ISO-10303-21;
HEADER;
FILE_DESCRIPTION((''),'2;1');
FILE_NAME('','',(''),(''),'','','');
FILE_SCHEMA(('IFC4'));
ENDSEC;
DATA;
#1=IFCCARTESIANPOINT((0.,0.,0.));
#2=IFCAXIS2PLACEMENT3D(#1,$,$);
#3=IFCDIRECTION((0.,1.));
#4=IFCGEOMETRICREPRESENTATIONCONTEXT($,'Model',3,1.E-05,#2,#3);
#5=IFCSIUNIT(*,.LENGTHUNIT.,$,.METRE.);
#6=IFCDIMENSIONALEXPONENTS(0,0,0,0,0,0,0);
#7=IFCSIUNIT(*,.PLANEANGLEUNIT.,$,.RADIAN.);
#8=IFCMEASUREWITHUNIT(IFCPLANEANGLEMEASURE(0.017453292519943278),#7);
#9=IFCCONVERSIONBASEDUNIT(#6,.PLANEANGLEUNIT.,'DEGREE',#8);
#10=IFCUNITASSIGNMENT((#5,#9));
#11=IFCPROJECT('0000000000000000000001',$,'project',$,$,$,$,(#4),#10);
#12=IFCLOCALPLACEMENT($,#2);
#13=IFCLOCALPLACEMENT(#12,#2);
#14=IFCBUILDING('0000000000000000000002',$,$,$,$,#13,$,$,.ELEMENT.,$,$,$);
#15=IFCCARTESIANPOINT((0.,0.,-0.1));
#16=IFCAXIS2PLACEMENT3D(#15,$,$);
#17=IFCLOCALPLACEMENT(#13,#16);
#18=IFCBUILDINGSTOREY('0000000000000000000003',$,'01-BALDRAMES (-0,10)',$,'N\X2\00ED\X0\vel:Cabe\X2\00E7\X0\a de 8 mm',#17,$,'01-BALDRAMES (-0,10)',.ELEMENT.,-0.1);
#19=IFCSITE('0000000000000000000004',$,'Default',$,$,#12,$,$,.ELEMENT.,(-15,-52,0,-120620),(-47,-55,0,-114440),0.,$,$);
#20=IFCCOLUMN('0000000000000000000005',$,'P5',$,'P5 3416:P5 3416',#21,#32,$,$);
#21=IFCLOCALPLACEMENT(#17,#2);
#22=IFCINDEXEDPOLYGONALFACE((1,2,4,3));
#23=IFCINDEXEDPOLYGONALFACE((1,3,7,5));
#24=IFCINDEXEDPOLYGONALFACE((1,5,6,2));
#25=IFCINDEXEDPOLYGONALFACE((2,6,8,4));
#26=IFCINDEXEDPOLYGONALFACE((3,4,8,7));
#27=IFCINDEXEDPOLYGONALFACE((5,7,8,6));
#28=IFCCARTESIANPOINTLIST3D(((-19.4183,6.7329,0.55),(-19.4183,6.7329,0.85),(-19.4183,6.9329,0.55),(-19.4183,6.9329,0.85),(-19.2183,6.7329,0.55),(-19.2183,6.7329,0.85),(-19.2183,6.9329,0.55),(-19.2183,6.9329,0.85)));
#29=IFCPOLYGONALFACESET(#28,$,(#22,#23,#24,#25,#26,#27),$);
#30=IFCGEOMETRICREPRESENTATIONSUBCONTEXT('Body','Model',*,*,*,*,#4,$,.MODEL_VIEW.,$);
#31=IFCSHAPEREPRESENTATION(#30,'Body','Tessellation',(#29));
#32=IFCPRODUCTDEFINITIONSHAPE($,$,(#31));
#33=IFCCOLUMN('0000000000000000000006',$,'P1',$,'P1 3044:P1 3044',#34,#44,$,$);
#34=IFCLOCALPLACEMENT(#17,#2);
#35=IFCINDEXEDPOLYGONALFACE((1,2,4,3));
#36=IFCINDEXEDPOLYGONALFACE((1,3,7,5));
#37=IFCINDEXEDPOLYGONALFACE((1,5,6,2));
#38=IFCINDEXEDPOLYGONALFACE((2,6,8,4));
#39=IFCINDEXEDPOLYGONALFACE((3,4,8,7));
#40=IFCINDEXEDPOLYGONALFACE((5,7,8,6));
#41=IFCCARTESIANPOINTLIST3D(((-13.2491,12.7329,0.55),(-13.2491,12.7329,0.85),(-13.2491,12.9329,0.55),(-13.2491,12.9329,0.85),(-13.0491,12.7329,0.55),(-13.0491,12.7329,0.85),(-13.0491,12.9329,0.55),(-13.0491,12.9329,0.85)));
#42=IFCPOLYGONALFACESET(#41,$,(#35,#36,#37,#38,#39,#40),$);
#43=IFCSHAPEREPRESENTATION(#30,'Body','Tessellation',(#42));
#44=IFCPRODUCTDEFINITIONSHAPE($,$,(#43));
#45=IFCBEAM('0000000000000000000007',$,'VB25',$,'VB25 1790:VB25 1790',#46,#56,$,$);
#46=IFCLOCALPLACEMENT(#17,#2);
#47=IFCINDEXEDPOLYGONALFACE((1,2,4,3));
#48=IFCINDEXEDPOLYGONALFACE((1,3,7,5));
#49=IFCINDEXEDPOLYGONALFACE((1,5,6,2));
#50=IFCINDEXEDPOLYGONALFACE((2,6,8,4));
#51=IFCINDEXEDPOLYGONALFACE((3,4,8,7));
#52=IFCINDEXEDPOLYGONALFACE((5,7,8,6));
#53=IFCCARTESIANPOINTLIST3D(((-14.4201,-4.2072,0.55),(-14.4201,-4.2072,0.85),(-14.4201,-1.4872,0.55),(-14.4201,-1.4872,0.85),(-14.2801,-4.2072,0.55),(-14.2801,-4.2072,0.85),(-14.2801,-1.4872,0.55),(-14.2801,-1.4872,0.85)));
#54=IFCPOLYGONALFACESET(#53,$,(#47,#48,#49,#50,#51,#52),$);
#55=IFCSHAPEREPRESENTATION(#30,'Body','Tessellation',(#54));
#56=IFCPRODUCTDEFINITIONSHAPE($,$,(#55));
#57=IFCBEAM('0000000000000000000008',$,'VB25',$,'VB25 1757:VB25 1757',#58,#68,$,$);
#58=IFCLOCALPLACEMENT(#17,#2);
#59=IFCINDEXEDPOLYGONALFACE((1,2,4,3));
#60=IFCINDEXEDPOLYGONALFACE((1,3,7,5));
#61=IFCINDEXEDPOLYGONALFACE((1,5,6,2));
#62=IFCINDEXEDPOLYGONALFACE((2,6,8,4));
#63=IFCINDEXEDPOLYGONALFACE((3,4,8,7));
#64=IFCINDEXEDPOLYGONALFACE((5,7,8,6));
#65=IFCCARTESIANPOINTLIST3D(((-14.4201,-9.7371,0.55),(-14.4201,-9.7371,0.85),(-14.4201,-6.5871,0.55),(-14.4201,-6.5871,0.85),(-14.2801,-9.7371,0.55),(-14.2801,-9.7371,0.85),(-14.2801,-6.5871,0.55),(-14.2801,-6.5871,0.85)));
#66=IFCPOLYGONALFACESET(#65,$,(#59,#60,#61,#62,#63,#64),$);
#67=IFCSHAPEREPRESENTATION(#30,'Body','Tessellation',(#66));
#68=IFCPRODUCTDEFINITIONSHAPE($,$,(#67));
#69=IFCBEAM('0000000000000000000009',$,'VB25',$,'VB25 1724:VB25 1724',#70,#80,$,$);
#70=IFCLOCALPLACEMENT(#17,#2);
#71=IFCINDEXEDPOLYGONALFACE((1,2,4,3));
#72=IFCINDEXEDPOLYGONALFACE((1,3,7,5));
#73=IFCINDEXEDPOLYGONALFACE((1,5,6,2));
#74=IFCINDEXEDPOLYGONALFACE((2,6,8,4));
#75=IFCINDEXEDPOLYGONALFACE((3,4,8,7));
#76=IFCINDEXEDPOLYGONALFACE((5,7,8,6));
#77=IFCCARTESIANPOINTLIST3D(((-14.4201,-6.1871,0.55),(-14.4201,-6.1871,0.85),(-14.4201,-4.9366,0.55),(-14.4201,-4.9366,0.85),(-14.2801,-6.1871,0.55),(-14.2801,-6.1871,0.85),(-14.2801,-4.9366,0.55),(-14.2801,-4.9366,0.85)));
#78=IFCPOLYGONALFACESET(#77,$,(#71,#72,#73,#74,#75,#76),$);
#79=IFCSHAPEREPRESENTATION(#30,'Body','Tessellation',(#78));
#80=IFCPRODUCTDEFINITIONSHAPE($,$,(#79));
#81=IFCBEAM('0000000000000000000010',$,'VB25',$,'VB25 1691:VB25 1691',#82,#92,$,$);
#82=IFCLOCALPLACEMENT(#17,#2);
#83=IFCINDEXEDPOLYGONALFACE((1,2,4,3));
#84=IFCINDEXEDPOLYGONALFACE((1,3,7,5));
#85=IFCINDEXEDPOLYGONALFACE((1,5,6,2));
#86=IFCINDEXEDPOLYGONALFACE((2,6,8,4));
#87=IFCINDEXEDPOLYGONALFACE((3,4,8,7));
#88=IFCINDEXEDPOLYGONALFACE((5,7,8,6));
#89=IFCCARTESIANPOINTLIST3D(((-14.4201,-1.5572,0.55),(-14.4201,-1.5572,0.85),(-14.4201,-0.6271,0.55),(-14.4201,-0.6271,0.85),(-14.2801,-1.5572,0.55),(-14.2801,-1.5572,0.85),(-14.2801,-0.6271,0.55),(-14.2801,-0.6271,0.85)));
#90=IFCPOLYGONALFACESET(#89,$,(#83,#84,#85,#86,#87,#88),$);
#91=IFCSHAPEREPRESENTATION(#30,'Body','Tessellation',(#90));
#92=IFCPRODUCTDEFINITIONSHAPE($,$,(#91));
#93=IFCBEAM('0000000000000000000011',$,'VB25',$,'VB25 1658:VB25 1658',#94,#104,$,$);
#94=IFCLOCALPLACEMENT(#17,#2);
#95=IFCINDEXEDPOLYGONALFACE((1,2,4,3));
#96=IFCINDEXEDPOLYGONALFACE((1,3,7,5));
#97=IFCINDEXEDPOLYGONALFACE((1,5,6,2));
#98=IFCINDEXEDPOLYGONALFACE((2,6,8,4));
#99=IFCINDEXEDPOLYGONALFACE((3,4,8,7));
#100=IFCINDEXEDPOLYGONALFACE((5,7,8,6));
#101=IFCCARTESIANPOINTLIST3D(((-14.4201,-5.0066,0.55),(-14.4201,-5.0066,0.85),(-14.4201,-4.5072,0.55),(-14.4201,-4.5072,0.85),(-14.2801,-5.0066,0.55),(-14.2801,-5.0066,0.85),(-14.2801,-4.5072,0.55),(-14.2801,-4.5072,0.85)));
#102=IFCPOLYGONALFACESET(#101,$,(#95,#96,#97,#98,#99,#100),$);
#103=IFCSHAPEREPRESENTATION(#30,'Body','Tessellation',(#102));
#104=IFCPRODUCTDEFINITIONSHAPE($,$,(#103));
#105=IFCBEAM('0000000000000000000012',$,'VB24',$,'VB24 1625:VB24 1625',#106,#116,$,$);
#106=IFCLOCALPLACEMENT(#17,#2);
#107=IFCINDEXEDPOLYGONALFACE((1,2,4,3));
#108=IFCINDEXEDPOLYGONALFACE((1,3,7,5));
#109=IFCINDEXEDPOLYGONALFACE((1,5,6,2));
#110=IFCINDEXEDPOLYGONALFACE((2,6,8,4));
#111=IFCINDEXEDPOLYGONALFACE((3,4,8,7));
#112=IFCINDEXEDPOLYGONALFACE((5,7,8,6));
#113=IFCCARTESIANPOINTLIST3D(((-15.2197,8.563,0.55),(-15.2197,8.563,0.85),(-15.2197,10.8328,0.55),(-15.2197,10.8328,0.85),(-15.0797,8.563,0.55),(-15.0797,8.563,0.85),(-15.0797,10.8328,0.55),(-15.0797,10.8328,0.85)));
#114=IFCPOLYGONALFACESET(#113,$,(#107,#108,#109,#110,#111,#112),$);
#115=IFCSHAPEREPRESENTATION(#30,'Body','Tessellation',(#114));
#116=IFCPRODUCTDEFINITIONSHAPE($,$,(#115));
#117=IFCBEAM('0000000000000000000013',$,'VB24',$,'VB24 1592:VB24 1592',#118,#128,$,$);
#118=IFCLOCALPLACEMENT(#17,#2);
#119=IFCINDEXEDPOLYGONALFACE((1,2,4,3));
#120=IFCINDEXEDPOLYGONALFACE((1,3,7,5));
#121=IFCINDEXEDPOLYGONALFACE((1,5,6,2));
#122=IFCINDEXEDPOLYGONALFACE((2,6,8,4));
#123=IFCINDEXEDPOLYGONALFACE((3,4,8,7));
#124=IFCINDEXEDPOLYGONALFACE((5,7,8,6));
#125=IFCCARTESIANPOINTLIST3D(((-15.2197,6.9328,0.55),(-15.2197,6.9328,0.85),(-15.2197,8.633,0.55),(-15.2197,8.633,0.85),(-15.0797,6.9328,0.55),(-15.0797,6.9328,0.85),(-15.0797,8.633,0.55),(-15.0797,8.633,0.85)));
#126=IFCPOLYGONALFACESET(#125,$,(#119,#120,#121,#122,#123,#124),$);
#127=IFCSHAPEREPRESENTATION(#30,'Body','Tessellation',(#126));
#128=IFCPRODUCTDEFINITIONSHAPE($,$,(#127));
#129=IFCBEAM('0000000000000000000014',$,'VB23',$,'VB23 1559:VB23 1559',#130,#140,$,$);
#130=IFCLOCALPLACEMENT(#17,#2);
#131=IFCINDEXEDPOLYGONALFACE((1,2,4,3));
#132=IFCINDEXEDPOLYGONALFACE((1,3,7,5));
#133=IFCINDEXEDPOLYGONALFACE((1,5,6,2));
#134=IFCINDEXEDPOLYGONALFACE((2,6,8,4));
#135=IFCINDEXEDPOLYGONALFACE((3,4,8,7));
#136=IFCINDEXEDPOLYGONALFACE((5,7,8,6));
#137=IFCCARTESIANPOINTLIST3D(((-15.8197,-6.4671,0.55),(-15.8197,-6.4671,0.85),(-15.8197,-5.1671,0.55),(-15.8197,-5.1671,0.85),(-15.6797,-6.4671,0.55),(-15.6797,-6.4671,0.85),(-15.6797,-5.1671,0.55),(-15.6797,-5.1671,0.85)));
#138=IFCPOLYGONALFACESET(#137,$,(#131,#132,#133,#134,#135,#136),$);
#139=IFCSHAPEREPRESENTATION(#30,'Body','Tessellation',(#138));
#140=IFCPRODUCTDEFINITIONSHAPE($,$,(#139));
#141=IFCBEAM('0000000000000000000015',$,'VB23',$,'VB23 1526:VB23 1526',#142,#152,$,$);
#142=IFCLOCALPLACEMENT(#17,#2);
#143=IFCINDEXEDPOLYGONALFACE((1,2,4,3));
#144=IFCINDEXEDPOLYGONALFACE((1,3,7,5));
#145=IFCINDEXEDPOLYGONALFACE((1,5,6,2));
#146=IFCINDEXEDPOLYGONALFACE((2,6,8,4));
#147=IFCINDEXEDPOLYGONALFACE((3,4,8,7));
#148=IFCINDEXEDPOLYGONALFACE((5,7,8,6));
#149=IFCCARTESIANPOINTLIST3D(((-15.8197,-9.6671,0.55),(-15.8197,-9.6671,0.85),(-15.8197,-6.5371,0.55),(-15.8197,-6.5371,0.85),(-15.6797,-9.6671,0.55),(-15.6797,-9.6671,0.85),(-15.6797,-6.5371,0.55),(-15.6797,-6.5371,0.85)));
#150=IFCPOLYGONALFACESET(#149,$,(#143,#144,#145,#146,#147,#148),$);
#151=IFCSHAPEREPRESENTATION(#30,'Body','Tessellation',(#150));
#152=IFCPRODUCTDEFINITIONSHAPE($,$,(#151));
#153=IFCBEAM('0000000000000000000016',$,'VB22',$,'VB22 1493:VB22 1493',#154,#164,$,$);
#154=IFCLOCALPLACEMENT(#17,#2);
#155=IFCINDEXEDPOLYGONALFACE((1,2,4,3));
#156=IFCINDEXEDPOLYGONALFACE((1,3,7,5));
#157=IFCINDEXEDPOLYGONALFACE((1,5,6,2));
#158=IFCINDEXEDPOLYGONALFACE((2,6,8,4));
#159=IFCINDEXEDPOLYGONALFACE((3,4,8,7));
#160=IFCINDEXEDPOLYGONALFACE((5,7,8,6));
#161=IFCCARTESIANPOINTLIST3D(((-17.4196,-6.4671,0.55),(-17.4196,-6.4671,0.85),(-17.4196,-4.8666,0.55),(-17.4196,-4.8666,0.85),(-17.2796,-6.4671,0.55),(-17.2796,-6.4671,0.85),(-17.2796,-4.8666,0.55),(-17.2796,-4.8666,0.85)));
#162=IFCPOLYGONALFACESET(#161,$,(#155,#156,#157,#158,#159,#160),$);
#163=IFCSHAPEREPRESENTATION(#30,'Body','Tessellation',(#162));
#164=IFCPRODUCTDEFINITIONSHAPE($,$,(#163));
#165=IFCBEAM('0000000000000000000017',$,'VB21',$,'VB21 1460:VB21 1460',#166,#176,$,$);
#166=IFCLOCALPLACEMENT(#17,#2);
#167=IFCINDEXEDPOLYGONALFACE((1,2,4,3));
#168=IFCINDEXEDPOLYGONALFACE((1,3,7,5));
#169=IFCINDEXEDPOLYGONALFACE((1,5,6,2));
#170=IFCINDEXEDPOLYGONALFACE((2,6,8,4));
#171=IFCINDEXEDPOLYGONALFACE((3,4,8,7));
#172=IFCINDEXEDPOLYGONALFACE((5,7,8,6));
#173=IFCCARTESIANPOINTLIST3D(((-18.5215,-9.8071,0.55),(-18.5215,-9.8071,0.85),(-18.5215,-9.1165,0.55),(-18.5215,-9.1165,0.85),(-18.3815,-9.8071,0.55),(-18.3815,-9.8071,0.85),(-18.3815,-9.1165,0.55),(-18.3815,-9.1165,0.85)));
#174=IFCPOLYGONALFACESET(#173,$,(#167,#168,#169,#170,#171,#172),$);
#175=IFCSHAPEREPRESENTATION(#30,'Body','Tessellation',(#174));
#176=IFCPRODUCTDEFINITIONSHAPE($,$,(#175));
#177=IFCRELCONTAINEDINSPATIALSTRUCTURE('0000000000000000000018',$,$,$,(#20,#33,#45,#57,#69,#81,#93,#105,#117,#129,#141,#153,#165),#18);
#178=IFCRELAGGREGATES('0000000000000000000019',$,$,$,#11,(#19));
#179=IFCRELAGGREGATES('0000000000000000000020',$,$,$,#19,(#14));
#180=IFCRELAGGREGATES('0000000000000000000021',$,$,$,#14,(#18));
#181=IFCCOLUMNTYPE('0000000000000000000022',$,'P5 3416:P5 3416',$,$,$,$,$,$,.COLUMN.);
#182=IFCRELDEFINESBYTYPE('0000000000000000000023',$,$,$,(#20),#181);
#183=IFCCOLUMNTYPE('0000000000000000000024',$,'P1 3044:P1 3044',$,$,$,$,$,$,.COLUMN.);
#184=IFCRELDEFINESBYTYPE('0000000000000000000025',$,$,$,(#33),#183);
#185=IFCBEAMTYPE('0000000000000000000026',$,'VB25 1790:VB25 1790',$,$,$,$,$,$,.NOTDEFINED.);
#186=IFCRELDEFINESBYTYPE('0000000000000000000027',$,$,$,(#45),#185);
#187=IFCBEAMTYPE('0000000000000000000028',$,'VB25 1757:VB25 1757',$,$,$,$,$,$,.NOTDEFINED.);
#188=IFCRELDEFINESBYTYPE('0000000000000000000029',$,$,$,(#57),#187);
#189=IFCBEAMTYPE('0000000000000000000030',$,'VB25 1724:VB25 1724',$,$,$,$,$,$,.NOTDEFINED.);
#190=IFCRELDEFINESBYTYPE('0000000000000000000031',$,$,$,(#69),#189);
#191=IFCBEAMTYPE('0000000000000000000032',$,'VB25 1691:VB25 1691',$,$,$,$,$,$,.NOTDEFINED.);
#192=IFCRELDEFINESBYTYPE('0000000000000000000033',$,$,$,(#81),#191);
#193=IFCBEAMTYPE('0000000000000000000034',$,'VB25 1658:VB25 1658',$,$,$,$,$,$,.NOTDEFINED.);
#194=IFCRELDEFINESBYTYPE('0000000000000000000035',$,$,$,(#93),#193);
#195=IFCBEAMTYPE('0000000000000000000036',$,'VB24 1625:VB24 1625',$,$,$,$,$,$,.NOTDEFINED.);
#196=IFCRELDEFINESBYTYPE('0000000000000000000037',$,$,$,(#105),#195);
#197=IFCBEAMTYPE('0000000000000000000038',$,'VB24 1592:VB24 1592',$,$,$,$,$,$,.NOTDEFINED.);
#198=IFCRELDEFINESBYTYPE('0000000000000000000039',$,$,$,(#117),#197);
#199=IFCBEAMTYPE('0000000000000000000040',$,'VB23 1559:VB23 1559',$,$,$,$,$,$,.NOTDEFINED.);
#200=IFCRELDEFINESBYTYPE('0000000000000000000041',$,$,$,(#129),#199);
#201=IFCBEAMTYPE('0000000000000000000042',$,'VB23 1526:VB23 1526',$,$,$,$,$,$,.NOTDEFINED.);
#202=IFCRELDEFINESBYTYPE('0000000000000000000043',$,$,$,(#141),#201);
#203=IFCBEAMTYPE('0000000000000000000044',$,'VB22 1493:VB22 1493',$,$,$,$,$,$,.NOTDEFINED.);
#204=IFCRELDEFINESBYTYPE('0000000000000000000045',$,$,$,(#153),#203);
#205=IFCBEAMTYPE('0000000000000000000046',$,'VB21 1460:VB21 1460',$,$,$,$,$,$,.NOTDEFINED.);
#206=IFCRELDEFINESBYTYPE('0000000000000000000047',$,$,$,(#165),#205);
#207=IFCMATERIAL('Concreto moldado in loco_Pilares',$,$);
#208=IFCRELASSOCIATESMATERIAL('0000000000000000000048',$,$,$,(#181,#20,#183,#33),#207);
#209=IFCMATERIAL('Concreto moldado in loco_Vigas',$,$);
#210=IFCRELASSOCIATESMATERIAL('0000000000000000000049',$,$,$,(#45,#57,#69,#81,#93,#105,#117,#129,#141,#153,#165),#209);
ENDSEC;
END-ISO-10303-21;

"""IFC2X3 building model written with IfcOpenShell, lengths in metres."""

from ifc_helpers import new_model, entity, si_unit, converted_unit, direction, frame, frame_2d, origin, origin_2d_with_axis, place, context, subcontext, project, spatial, rectangle, extrude, source, transform, mapped, material, type_object, type_shapes, element, save


model = new_model("IFC2X3")

# Units and contexts
model_context = context("Model", 3, precision=1e-05, world=origin(), true_north=direction((0.0, 1.0)))
body_context = subcontext(model_context, "Body", "Model", "MODEL_VIEW")
ifc_project = project(units=[si_unit("LENGTHUNIT", "METRE"), converted_unit("PLANEANGLEUNIT", "DEGREE", entity("IfcPlaneAngleMeasure", 0.017453292519943278), si_unit("PLANEANGLEUNIT", "RADIAN"), dimensions=[0, 0, 0, 0, 0, 0, 0])], contexts=[model_context])

# Site, building, storey
site_placement = place(None, origin())
site = spatial("IfcSite", under=ifc_project, at=site_placement, Name="Default", CompositionType="ELEMENT", RefLatitude=(-15, -52, 0, -120620), RefLongitude=(-47, -55, 0, -114440), RefElevation=0.0)
building_placement = place(site_placement, origin())
building = spatial("IfcBuilding", under=site, at=building_placement, CompositionType="ELEMENT")
storey_placement = place(building_placement, frame((0.0, 0.0, -0.1)))
storey = spatial("IfcBuildingStorey", under=building, at=storey_placement, Name="01-BALDRAMES (-0,10)", ObjectType="Nível:Cabeça de 8 mm", LongName="01-BALDRAMES (-0,10)", CompositionType="ELEMENT", Elevation=-0.1)

# Columns
ifc_material_1 = material(Name="Concreto moldado in loco_Pilares")
column_type_1 = type_object("IfcColumnType", Name="P5 3416:P5 3416", PredefinedType="COLUMN", material=ifc_material_1)
shared_shape_1 = source(origin(), body_context, "Body", "SweptSolid", [
    extrude(rectangle(XDim=0.2, YDim=0.2, at=origin_2d_with_axis()), frame((0.0, 0.0, 0.45), z_axis=(0.0, 0.0, 1.0), x_axis=(0.0, -1.0, 0.0)), (0.0, 0.0, 1.0), 0.3),
])
type_shapes(column_type_1, [shared_shape_1])
column_1_placement = place(storey_placement, frame((-19.3183, 6.8329, 0.1)))
element("IfcColumn", 1, at=column_1_placement, inside=storey, type_object=column_type_1, material=ifc_material_1, Name="P5", ObjectType="P5 3416:P5 3416", context=body_context, shape_type="MappedRepresentation", body=[
    mapped(shared_shape_1, transform((0.0, 0.0, 0.0), scale=1.0)),
])
column_type_2 = type_object("IfcColumnType", Name="P1 3044:P1 3044", PredefinedType="COLUMN", material=ifc_material_1)
shared_shape_2 = source(origin(), body_context, "Body", "SweptSolid", [
    extrude(rectangle(XDim=0.2, YDim=0.2, at=origin_2d_with_axis()), frame((0.0, 0.0, 0.45), z_axis=(0.0, 0.0, 1.0), x_axis=(0.0, 1.0, 0.0)), (0.0, 0.0, 1.0), 0.3),
])
type_shapes(column_type_2, [shared_shape_2])
column_2_placement = place(storey_placement, frame((-13.1491, 12.8329, 0.1)))
element("IfcColumn", 2, at=column_2_placement, inside=storey, type_object=column_type_2, material=ifc_material_1, Name="P1", ObjectType="P1 3044:P1 3044", context=body_context, shape_type="MappedRepresentation", body=[
    mapped(shared_shape_2, transform((0.0, 0.0, 0.0), scale=1.0)),
])

# Beams
ifc_material_2 = material(Name="Concreto moldado in loco_Vigas")
beam_type_1 = type_object("IfcBeamType", Name="VB25 1790:VB25 1790", PredefinedType="NOTDEFINED")
beam_1_placement = place(storey_placement, origin())
element("IfcBeam", 3, at=beam_1_placement, inside=storey, type_object=beam_type_1, material=ifc_material_2, Name="VB25", ObjectType="VB25 1790:VB25 1790", context=body_context, shape_type="SweptSolid", body=[
    extrude(rectangle(XDim=0.3, YDim=2.72, at=frame_2d((0.0, 0.0), x_axis=(0.0, 1.0))), frame((-14.4201, -2.8472, 0.7), z_axis=(1.0, 0.0, 0.0), x_axis=(0.0, -1.0, 0.0)), (0.0, 0.0, 1.0), 0.14),
])
beam_type_2 = type_object("IfcBeamType", Name="VB25 1757:VB25 1757", PredefinedType="NOTDEFINED")
beam_2_placement = place(storey_placement, origin())
element("IfcBeam", 4, at=beam_2_placement, inside=storey, type_object=beam_type_2, material=ifc_material_2, Name="VB25", ObjectType="VB25 1757:VB25 1757", context=body_context, shape_type="SweptSolid", body=[
    extrude(rectangle(XDim=0.3, YDim=3.15, at=frame_2d((0.0, 0.0), x_axis=(0.0, 1.0))), frame((-14.4201, -8.1621, 0.7), z_axis=(1.0, 0.0, 0.0), x_axis=(0.0, -1.0, 0.0)), (0.0, 0.0, 1.0), 0.14),
])
beam_type_3 = type_object("IfcBeamType", Name="VB25 1724:VB25 1724", PredefinedType="NOTDEFINED")
beam_3_placement = place(storey_placement, origin())
element("IfcBeam", 5, at=beam_3_placement, inside=storey, type_object=beam_type_3, material=ifc_material_2, Name="VB25", ObjectType="VB25 1724:VB25 1724", context=body_context, shape_type="SweptSolid", body=[
    extrude(rectangle(XDim=0.3, YDim=1.2505, at=frame_2d((0.0, 0.0), x_axis=(0.0, 1.0))), frame((-14.4201, -5.5618, 0.7), z_axis=(1.0, 0.0, 0.0), x_axis=(0.0, -1.0, 0.0)), (0.0, 0.0, 1.0), 0.14),
])
beam_type_4 = type_object("IfcBeamType", Name="VB25 1691:VB25 1691", PredefinedType="NOTDEFINED")
beam_4_placement = place(storey_placement, origin())
element("IfcBeam", 6, at=beam_4_placement, inside=storey, type_object=beam_type_4, material=ifc_material_2, Name="VB25", ObjectType="VB25 1691:VB25 1691", context=body_context, shape_type="SweptSolid", body=[
    extrude(rectangle(XDim=0.3, YDim=0.9301, at=frame_2d((0.0, 0.0), x_axis=(0.0, 1.0))), frame((-14.4201, -1.0921, 0.7), z_axis=(1.0, 0.0, 0.0), x_axis=(0.0, -1.0, 0.0)), (0.0, 0.0, 1.0), 0.14),
])
beam_type_5 = type_object("IfcBeamType", Name="VB25 1658:VB25 1658", PredefinedType="NOTDEFINED")
beam_5_placement = place(storey_placement, origin())
element("IfcBeam", 7, at=beam_5_placement, inside=storey, type_object=beam_type_5, material=ifc_material_2, Name="VB25", ObjectType="VB25 1658:VB25 1658", context=body_context, shape_type="SweptSolid", body=[
    extrude(rectangle(XDim=0.3, YDim=0.4994, at=frame_2d((0.0, 0.0), x_axis=(0.0, 1.0))), frame((-14.4201, -4.7569, 0.7), z_axis=(1.0, 0.0, 0.0), x_axis=(0.0, -1.0, 0.0)), (0.0, 0.0, 1.0), 0.14),
])
beam_type_6 = type_object("IfcBeamType", Name="VB24 1625:VB24 1625", PredefinedType="NOTDEFINED")
beam_6_placement = place(storey_placement, origin())
element("IfcBeam", 8, at=beam_6_placement, inside=storey, type_object=beam_type_6, material=ifc_material_2, Name="VB24", ObjectType="VB24 1625:VB24 1625", context=body_context, shape_type="SweptSolid", body=[
    extrude(rectangle(XDim=0.3, YDim=2.2698, at=frame_2d((0.0, 0.0), x_axis=(0.0, 1.0))), frame((-15.2197, 9.6979, 0.7), z_axis=(1.0, 0.0, 0.0), x_axis=(0.0, -1.0, 0.0)), (0.0, 0.0, 1.0), 0.14),
])
beam_type_7 = type_object("IfcBeamType", Name="VB24 1592:VB24 1592", PredefinedType="NOTDEFINED")
beam_7_placement = place(storey_placement, origin())
element("IfcBeam", 9, at=beam_7_placement, inside=storey, type_object=beam_type_7, material=ifc_material_2, Name="VB24", ObjectType="VB24 1592:VB24 1592", context=body_context, shape_type="SweptSolid", body=[
    extrude(rectangle(XDim=0.3, YDim=1.7002, at=frame_2d((0.0, 0.0), x_axis=(0.0, 1.0))), frame((-15.2197, 7.7829, 0.7), z_axis=(1.0, 0.0, 0.0), x_axis=(0.0, -1.0, 0.0)), (0.0, 0.0, 1.0), 0.14),
])
beam_type_8 = type_object("IfcBeamType", Name="VB23 1559:VB23 1559", PredefinedType="NOTDEFINED")
beam_8_placement = place(storey_placement, origin())
element("IfcBeam", 10, at=beam_8_placement, inside=storey, type_object=beam_type_8, material=ifc_material_2, Name="VB23", ObjectType="VB23 1559:VB23 1559", context=body_context, shape_type="SweptSolid", body=[
    extrude(rectangle(XDim=0.3, YDim=1.3, at=frame_2d((0.0, 0.0), x_axis=(0.0, 1.0))), frame((-15.8197, -5.8171, 0.7), z_axis=(1.0, 0.0, 0.0), x_axis=(0.0, -1.0, 0.0)), (0.0, 0.0, 1.0), 0.14),
])
beam_type_9 = type_object("IfcBeamType", Name="VB23 1526:VB23 1526", PredefinedType="NOTDEFINED")
beam_9_placement = place(storey_placement, origin())
element("IfcBeam", 11, at=beam_9_placement, inside=storey, type_object=beam_type_9, material=ifc_material_2, Name="VB23", ObjectType="VB23 1526:VB23 1526", context=body_context, shape_type="SweptSolid", body=[
    extrude(rectangle(XDim=0.3, YDim=3.13, at=frame_2d((0.0, 0.0), x_axis=(0.0, 1.0))), frame((-15.8197, -8.1021, 0.7), z_axis=(1.0, 0.0, 0.0), x_axis=(0.0, -1.0, 0.0)), (0.0, 0.0, 1.0), 0.14),
])
beam_type_10 = type_object("IfcBeamType", Name="VB22 1493:VB22 1493", PredefinedType="NOTDEFINED")
beam_10_placement = place(storey_placement, origin())
element("IfcBeam", 12, at=beam_10_placement, inside=storey, type_object=beam_type_10, material=ifc_material_2, Name="VB22", ObjectType="VB22 1493:VB22 1493", context=body_context, shape_type="SweptSolid", body=[
    extrude(rectangle(XDim=0.3, YDim=1.6005, at=frame_2d((0.0, 0.0), x_axis=(0.0, 1.0))), frame((-17.4196, -5.6668, 0.7), z_axis=(1.0, 0.0, 0.0), x_axis=(0.0, -1.0, 0.0)), (0.0, 0.0, 1.0), 0.14),
])
beam_type_11 = type_object("IfcBeamType", Name="VB21 1460:VB21 1460", PredefinedType="NOTDEFINED")
beam_11_placement = place(storey_placement, origin())
element("IfcBeam", 13, at=beam_11_placement, inside=storey, type_object=beam_type_11, material=ifc_material_2, Name="VB21", ObjectType="VB21 1460:VB21 1460", context=body_context, shape_type="SweptSolid", body=[
    extrude(rectangle(XDim=0.3, YDim=0.6906, at=frame_2d((0.0, 0.0), x_axis=(0.0, 1.0))), frame((-18.5215, -9.4618, 0.7), z_axis=(1.0, 0.0, 0.0), x_axis=(0.0, -1.0, 0.0)), (0.0, 0.0, 1.0), 0.14),
])

save(model, "model.ifc")
